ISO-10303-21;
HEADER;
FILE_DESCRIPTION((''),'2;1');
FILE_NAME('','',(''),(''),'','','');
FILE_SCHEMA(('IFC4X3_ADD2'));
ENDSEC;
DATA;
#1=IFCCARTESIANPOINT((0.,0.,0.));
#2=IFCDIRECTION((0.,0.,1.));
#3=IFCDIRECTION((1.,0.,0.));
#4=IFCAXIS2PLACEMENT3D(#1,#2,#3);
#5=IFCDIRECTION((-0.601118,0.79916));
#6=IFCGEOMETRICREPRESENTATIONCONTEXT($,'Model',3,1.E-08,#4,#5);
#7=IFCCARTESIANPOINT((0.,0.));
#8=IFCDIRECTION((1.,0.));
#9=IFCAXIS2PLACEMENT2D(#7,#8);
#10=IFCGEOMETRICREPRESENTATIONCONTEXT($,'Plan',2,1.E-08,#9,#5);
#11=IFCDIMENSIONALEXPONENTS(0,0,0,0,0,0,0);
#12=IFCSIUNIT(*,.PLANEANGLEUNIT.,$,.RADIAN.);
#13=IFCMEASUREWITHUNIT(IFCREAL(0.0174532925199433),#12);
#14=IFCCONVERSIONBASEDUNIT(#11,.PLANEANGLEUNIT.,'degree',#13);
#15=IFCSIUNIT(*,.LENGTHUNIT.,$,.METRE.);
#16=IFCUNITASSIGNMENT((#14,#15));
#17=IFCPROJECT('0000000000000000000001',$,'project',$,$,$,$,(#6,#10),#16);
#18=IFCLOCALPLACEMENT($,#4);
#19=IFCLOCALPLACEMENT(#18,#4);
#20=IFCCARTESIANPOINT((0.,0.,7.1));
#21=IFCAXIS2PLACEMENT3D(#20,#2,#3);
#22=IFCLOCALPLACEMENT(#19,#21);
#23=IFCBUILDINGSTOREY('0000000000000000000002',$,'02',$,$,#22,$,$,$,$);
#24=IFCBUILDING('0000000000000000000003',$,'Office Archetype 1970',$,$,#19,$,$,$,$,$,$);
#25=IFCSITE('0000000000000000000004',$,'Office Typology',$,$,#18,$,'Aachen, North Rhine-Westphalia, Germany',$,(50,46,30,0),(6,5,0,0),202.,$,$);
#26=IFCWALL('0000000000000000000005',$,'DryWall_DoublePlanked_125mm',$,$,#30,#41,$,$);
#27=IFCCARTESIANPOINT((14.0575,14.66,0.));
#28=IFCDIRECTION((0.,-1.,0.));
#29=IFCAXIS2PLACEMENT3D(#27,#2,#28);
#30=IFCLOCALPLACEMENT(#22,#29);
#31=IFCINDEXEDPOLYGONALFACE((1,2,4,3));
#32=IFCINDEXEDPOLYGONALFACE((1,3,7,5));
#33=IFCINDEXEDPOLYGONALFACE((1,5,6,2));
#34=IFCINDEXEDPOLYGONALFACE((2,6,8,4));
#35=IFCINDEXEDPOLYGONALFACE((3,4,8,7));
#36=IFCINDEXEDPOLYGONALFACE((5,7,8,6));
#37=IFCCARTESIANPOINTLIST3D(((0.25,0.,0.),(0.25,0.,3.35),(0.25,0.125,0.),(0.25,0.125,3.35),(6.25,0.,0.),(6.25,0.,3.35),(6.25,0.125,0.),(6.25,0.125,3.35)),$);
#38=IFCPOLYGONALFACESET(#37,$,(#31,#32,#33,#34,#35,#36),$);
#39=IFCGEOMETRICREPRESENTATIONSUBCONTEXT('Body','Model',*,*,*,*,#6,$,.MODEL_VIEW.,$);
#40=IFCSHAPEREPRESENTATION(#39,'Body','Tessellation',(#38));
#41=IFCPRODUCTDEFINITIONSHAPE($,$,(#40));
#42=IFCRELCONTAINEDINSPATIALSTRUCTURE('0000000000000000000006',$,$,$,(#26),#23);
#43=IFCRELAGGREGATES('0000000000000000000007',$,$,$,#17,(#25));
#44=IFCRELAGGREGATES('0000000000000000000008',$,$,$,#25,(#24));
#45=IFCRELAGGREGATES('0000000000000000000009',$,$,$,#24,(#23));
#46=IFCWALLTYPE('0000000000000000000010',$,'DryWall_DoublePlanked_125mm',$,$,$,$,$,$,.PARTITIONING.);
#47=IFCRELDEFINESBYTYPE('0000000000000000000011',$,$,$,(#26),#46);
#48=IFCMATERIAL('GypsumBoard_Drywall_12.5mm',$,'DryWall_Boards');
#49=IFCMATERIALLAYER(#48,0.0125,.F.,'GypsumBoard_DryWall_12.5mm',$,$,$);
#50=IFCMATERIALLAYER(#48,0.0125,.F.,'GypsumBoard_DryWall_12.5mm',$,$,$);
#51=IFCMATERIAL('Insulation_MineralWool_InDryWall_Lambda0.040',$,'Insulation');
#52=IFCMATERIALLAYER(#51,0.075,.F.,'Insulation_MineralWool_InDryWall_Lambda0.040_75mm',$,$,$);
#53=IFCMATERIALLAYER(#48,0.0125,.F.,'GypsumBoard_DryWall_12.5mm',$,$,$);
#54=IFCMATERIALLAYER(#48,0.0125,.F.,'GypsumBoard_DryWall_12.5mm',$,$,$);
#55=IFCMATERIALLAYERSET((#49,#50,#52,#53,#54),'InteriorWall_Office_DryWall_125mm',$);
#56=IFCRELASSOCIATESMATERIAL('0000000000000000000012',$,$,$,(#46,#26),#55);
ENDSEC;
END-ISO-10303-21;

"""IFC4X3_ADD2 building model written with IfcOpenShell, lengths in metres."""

from ifc_helpers import new_model, entity, si_unit, converted_unit, direction, frame, origin_with_axes, origin_2d_with_axis, place, context, subcontext, project, spatial, line, indexed_curve, outline, extrude, material, layer, layer_set, layer_usage, type_object, element, save


model = new_model("IFC4X3_ADD2")

# Units and contexts
model_context = context("Model", 3, precision=1e-08, world=origin_with_axes(), true_north=direction((-0.601118, 0.79916)))
plan_context = context("Plan", 2, precision=1e-08, world=origin_2d_with_axis(), true_north=direction((-0.601118, 0.79916)))
body_context = subcontext(model_context, "Body", "Model", "MODEL_VIEW")
ifc_project = project(units=[converted_unit("PLANEANGLEUNIT", "degree", entity("IfcReal", 0.0174532925199433), si_unit("PLANEANGLEUNIT", "RADIAN"), dimensions=[0, 0, 0, 0, 0, 0, 0]), si_unit("LENGTHUNIT", "METRE")], contexts=[model_context, plan_context])

# Site, building, storey
site_placement = place(None, origin_with_axes())
site = spatial("IfcSite", under=ifc_project, at=site_placement, Name="Office Typology", LongName="Aachen, North Rhine-Westphalia, Germany", RefLatitude=(50, 46, 30, 0), RefLongitude=(6, 5, 0, 0), RefElevation=202.0)
building_placement = place(site_placement, origin_with_axes())
building = spatial("IfcBuilding", under=site, at=building_placement, Name="Office Archetype 1970")
storey_placement = place(building_placement, frame((0.0, 0.0, 7.1), z_axis=(0.0, 0.0, 1.0), x_axis=(1.0, 0.0, 0.0)))
storey = spatial("IfcBuildingStorey", under=building, at=storey_placement, Name="02")

# Wall
ifc_material_1 = material(Name="GypsumBoard_Drywall_12.5mm", Category="DryWall_Boards")
ifc_layer_1 = layer(ifc_material_1, 0.0125, ventilated=False, Name="GypsumBoard_DryWall_12.5mm")
ifc_layer_2 = layer(ifc_material_1, 0.0125, ventilated=False, Name="GypsumBoard_DryWall_12.5mm")
ifc_material_2 = material(Name="Insulation_MineralWool_InDryWall_Lambda0.040", Category="Insulation")
ifc_layer_3 = layer(ifc_material_2, 0.075, ventilated=False, Name="Insulation_MineralWool_InDryWall_Lambda0.040_75mm")
ifc_layer_4 = layer(ifc_material_1, 0.0125, ventilated=False, Name="GypsumBoard_DryWall_12.5mm")
ifc_layer_5 = layer(ifc_material_1, 0.0125, ventilated=False, Name="GypsumBoard_DryWall_12.5mm")
ifc_layer_set_1 = layer_set([ifc_layer_1, ifc_layer_2, ifc_layer_3, ifc_layer_4, ifc_layer_5], Name="InteriorWall_Office_DryWall_125mm")
ifc_layer_usage = layer_usage(ifc_layer_set_1, "AXIS2", "POSITIVE", 0.0)
wall_type_1 = type_object("IfcWallType", Name="DryWall_DoublePlanked_125mm", PredefinedType="PARTITIONING", material=ifc_layer_set_1)
wall_1_placement = place(storey_placement, frame((14.0575, 14.66, 0.0), z_axis=(0.0, 0.0, 1.0), x_axis=(0.0, -1.0, 0.0)))
element("IfcWall", 1, at=wall_1_placement, inside=storey, type_object=wall_type_1, material=ifc_layer_usage, Name="DryWall_DoublePlanked_125mm", context=body_context, shape_type="SweptSolid", body=[
    extrude(outline(indexed_curve([(0.25, 0.0), (0.25, 0.125), (6.25, 0.125), (6.25, 0.0)], segments=[line(1, 2, 3, 4, 1)])), origin_with_axes(), (0.0, 0.0, 1.0), 3.35),
])

save(model, "model.ifc")
